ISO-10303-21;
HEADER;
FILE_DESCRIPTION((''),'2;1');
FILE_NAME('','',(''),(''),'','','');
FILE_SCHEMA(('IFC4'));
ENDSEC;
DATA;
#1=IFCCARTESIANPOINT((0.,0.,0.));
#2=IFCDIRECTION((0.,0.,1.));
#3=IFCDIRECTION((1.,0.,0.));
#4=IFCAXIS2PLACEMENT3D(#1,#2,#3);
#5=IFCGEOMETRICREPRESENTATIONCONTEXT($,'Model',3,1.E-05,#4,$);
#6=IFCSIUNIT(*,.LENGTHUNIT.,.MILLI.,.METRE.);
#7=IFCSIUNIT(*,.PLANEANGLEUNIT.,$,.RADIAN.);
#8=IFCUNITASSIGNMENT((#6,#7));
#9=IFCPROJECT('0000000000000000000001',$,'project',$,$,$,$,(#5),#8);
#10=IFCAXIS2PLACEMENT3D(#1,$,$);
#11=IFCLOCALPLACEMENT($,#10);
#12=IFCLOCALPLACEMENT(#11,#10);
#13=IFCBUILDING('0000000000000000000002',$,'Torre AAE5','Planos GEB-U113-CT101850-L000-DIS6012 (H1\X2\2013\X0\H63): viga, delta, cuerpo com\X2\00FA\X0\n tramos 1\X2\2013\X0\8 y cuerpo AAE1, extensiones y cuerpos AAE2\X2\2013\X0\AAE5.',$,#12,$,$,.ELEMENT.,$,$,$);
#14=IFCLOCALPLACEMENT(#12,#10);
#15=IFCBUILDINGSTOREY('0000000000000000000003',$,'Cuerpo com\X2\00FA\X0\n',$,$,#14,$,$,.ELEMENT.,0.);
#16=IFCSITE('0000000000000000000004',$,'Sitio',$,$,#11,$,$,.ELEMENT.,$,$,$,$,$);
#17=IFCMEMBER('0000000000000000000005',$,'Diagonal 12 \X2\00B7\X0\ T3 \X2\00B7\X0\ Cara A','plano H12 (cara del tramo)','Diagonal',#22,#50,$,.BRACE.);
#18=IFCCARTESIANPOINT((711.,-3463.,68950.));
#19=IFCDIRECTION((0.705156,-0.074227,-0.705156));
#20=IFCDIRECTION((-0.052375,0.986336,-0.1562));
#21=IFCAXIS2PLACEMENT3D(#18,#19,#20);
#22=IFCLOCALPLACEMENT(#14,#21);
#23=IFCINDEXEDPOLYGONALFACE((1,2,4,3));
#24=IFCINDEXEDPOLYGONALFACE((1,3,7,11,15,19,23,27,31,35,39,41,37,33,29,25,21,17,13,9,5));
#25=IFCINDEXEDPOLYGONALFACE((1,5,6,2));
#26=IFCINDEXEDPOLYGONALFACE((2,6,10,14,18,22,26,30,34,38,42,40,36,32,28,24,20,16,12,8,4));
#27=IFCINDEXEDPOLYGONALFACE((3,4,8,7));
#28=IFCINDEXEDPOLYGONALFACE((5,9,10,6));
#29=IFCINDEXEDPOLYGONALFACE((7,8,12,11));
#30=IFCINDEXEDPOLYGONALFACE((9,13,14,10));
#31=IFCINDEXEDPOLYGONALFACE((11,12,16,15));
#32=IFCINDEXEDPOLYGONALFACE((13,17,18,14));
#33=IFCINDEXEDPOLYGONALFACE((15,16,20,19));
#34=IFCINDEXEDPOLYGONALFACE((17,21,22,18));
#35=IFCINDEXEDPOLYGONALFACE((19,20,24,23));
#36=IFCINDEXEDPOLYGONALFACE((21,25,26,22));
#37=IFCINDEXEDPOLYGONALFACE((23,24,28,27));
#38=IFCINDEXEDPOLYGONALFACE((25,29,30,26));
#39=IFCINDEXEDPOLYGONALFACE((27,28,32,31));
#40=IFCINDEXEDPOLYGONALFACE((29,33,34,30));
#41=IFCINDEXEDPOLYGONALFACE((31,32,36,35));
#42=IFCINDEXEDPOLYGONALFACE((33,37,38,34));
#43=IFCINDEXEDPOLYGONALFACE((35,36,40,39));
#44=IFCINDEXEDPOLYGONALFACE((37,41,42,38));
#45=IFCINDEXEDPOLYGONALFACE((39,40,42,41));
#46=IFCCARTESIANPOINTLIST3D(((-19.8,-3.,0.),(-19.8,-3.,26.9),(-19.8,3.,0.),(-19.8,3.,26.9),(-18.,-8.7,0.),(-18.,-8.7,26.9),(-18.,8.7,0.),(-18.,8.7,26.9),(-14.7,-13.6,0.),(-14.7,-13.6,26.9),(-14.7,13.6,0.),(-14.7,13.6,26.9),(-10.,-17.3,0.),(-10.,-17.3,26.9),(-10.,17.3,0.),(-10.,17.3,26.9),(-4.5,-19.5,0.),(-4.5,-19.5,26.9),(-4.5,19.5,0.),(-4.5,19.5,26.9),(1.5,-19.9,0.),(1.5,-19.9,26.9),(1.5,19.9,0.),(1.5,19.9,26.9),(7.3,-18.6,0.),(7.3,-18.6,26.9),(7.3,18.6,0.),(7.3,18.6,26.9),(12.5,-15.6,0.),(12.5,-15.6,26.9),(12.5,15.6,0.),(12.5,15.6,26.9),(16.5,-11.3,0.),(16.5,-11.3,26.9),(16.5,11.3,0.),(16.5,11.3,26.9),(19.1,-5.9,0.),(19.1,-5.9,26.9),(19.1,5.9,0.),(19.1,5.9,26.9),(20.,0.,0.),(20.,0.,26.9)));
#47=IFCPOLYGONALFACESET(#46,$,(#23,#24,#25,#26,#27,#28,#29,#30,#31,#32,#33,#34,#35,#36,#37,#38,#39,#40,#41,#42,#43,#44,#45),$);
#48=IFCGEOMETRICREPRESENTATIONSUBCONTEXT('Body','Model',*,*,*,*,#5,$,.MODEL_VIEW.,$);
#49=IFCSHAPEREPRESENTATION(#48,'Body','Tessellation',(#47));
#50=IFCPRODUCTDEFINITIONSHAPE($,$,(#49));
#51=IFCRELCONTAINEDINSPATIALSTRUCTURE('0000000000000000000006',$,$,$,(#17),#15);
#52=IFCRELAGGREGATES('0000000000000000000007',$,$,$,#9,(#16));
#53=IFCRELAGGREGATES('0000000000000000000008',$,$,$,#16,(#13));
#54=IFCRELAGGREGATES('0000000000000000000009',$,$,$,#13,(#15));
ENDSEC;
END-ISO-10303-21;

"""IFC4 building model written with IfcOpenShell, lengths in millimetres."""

from ifc_helpers import new_model, si_unit, frame, origin, origin_with_axes, place, context, subcontext, project, spatial, circle, extrude, element, save


model = new_model("IFC4")

# Units and contexts
model_context = context("Model", 3, precision=1e-05, world=origin_with_axes())
body_context = subcontext(model_context, "Body", "Model", "MODEL_VIEW")
ifc_project = project(units=[si_unit("LENGTHUNIT", "METRE", prefix="MILLI"), si_unit("PLANEANGLEUNIT", "RADIAN")], contexts=[model_context])

# Site, building, storey
site_placement = place(None, origin())
site = spatial("IfcSite", under=ifc_project, at=site_placement, Name="Sitio", CompositionType="ELEMENT")
building_placement = place(site_placement, origin())
building = spatial("IfcBuilding", under=site, at=building_placement, Name="Torre AAE5", Description="Planos GEB-U113-CT101850-L000-DIS6012 (H1–H63): viga, delta, cuerpo común tramos 1–8 y cuerpo AAE1, extensiones y cuerpos AAE2–AAE5.", CompositionType="ELEMENT")
storey_placement = place(building_placement, origin())
storey = spatial("IfcBuildingStorey", under=building, at=storey_placement, Name="Cuerpo común", CompositionType="ELEMENT", Elevation=0.0)

# Member
member_1_placement = place(storey_placement, frame((711.0, -3463.0, 68950.0), z_axis=(0.705156, -0.074227, -0.705156), x_axis=(-0.052375, 0.986336, -0.1562)))
element("IfcMember", 1, at=member_1_placement, inside=storey, Name="Diagonal 12 · T3 · Cara A", Description="plano H12 (cara del tramo)", ObjectType="Diagonal", PredefinedType="BRACE", context=body_context, shape_type="SweptSolid", body=[
    extrude(circle(Radius=20.0), None, (0.0, 0.0, 1.0), 26.9),
])

save(model, "model.ifc")
